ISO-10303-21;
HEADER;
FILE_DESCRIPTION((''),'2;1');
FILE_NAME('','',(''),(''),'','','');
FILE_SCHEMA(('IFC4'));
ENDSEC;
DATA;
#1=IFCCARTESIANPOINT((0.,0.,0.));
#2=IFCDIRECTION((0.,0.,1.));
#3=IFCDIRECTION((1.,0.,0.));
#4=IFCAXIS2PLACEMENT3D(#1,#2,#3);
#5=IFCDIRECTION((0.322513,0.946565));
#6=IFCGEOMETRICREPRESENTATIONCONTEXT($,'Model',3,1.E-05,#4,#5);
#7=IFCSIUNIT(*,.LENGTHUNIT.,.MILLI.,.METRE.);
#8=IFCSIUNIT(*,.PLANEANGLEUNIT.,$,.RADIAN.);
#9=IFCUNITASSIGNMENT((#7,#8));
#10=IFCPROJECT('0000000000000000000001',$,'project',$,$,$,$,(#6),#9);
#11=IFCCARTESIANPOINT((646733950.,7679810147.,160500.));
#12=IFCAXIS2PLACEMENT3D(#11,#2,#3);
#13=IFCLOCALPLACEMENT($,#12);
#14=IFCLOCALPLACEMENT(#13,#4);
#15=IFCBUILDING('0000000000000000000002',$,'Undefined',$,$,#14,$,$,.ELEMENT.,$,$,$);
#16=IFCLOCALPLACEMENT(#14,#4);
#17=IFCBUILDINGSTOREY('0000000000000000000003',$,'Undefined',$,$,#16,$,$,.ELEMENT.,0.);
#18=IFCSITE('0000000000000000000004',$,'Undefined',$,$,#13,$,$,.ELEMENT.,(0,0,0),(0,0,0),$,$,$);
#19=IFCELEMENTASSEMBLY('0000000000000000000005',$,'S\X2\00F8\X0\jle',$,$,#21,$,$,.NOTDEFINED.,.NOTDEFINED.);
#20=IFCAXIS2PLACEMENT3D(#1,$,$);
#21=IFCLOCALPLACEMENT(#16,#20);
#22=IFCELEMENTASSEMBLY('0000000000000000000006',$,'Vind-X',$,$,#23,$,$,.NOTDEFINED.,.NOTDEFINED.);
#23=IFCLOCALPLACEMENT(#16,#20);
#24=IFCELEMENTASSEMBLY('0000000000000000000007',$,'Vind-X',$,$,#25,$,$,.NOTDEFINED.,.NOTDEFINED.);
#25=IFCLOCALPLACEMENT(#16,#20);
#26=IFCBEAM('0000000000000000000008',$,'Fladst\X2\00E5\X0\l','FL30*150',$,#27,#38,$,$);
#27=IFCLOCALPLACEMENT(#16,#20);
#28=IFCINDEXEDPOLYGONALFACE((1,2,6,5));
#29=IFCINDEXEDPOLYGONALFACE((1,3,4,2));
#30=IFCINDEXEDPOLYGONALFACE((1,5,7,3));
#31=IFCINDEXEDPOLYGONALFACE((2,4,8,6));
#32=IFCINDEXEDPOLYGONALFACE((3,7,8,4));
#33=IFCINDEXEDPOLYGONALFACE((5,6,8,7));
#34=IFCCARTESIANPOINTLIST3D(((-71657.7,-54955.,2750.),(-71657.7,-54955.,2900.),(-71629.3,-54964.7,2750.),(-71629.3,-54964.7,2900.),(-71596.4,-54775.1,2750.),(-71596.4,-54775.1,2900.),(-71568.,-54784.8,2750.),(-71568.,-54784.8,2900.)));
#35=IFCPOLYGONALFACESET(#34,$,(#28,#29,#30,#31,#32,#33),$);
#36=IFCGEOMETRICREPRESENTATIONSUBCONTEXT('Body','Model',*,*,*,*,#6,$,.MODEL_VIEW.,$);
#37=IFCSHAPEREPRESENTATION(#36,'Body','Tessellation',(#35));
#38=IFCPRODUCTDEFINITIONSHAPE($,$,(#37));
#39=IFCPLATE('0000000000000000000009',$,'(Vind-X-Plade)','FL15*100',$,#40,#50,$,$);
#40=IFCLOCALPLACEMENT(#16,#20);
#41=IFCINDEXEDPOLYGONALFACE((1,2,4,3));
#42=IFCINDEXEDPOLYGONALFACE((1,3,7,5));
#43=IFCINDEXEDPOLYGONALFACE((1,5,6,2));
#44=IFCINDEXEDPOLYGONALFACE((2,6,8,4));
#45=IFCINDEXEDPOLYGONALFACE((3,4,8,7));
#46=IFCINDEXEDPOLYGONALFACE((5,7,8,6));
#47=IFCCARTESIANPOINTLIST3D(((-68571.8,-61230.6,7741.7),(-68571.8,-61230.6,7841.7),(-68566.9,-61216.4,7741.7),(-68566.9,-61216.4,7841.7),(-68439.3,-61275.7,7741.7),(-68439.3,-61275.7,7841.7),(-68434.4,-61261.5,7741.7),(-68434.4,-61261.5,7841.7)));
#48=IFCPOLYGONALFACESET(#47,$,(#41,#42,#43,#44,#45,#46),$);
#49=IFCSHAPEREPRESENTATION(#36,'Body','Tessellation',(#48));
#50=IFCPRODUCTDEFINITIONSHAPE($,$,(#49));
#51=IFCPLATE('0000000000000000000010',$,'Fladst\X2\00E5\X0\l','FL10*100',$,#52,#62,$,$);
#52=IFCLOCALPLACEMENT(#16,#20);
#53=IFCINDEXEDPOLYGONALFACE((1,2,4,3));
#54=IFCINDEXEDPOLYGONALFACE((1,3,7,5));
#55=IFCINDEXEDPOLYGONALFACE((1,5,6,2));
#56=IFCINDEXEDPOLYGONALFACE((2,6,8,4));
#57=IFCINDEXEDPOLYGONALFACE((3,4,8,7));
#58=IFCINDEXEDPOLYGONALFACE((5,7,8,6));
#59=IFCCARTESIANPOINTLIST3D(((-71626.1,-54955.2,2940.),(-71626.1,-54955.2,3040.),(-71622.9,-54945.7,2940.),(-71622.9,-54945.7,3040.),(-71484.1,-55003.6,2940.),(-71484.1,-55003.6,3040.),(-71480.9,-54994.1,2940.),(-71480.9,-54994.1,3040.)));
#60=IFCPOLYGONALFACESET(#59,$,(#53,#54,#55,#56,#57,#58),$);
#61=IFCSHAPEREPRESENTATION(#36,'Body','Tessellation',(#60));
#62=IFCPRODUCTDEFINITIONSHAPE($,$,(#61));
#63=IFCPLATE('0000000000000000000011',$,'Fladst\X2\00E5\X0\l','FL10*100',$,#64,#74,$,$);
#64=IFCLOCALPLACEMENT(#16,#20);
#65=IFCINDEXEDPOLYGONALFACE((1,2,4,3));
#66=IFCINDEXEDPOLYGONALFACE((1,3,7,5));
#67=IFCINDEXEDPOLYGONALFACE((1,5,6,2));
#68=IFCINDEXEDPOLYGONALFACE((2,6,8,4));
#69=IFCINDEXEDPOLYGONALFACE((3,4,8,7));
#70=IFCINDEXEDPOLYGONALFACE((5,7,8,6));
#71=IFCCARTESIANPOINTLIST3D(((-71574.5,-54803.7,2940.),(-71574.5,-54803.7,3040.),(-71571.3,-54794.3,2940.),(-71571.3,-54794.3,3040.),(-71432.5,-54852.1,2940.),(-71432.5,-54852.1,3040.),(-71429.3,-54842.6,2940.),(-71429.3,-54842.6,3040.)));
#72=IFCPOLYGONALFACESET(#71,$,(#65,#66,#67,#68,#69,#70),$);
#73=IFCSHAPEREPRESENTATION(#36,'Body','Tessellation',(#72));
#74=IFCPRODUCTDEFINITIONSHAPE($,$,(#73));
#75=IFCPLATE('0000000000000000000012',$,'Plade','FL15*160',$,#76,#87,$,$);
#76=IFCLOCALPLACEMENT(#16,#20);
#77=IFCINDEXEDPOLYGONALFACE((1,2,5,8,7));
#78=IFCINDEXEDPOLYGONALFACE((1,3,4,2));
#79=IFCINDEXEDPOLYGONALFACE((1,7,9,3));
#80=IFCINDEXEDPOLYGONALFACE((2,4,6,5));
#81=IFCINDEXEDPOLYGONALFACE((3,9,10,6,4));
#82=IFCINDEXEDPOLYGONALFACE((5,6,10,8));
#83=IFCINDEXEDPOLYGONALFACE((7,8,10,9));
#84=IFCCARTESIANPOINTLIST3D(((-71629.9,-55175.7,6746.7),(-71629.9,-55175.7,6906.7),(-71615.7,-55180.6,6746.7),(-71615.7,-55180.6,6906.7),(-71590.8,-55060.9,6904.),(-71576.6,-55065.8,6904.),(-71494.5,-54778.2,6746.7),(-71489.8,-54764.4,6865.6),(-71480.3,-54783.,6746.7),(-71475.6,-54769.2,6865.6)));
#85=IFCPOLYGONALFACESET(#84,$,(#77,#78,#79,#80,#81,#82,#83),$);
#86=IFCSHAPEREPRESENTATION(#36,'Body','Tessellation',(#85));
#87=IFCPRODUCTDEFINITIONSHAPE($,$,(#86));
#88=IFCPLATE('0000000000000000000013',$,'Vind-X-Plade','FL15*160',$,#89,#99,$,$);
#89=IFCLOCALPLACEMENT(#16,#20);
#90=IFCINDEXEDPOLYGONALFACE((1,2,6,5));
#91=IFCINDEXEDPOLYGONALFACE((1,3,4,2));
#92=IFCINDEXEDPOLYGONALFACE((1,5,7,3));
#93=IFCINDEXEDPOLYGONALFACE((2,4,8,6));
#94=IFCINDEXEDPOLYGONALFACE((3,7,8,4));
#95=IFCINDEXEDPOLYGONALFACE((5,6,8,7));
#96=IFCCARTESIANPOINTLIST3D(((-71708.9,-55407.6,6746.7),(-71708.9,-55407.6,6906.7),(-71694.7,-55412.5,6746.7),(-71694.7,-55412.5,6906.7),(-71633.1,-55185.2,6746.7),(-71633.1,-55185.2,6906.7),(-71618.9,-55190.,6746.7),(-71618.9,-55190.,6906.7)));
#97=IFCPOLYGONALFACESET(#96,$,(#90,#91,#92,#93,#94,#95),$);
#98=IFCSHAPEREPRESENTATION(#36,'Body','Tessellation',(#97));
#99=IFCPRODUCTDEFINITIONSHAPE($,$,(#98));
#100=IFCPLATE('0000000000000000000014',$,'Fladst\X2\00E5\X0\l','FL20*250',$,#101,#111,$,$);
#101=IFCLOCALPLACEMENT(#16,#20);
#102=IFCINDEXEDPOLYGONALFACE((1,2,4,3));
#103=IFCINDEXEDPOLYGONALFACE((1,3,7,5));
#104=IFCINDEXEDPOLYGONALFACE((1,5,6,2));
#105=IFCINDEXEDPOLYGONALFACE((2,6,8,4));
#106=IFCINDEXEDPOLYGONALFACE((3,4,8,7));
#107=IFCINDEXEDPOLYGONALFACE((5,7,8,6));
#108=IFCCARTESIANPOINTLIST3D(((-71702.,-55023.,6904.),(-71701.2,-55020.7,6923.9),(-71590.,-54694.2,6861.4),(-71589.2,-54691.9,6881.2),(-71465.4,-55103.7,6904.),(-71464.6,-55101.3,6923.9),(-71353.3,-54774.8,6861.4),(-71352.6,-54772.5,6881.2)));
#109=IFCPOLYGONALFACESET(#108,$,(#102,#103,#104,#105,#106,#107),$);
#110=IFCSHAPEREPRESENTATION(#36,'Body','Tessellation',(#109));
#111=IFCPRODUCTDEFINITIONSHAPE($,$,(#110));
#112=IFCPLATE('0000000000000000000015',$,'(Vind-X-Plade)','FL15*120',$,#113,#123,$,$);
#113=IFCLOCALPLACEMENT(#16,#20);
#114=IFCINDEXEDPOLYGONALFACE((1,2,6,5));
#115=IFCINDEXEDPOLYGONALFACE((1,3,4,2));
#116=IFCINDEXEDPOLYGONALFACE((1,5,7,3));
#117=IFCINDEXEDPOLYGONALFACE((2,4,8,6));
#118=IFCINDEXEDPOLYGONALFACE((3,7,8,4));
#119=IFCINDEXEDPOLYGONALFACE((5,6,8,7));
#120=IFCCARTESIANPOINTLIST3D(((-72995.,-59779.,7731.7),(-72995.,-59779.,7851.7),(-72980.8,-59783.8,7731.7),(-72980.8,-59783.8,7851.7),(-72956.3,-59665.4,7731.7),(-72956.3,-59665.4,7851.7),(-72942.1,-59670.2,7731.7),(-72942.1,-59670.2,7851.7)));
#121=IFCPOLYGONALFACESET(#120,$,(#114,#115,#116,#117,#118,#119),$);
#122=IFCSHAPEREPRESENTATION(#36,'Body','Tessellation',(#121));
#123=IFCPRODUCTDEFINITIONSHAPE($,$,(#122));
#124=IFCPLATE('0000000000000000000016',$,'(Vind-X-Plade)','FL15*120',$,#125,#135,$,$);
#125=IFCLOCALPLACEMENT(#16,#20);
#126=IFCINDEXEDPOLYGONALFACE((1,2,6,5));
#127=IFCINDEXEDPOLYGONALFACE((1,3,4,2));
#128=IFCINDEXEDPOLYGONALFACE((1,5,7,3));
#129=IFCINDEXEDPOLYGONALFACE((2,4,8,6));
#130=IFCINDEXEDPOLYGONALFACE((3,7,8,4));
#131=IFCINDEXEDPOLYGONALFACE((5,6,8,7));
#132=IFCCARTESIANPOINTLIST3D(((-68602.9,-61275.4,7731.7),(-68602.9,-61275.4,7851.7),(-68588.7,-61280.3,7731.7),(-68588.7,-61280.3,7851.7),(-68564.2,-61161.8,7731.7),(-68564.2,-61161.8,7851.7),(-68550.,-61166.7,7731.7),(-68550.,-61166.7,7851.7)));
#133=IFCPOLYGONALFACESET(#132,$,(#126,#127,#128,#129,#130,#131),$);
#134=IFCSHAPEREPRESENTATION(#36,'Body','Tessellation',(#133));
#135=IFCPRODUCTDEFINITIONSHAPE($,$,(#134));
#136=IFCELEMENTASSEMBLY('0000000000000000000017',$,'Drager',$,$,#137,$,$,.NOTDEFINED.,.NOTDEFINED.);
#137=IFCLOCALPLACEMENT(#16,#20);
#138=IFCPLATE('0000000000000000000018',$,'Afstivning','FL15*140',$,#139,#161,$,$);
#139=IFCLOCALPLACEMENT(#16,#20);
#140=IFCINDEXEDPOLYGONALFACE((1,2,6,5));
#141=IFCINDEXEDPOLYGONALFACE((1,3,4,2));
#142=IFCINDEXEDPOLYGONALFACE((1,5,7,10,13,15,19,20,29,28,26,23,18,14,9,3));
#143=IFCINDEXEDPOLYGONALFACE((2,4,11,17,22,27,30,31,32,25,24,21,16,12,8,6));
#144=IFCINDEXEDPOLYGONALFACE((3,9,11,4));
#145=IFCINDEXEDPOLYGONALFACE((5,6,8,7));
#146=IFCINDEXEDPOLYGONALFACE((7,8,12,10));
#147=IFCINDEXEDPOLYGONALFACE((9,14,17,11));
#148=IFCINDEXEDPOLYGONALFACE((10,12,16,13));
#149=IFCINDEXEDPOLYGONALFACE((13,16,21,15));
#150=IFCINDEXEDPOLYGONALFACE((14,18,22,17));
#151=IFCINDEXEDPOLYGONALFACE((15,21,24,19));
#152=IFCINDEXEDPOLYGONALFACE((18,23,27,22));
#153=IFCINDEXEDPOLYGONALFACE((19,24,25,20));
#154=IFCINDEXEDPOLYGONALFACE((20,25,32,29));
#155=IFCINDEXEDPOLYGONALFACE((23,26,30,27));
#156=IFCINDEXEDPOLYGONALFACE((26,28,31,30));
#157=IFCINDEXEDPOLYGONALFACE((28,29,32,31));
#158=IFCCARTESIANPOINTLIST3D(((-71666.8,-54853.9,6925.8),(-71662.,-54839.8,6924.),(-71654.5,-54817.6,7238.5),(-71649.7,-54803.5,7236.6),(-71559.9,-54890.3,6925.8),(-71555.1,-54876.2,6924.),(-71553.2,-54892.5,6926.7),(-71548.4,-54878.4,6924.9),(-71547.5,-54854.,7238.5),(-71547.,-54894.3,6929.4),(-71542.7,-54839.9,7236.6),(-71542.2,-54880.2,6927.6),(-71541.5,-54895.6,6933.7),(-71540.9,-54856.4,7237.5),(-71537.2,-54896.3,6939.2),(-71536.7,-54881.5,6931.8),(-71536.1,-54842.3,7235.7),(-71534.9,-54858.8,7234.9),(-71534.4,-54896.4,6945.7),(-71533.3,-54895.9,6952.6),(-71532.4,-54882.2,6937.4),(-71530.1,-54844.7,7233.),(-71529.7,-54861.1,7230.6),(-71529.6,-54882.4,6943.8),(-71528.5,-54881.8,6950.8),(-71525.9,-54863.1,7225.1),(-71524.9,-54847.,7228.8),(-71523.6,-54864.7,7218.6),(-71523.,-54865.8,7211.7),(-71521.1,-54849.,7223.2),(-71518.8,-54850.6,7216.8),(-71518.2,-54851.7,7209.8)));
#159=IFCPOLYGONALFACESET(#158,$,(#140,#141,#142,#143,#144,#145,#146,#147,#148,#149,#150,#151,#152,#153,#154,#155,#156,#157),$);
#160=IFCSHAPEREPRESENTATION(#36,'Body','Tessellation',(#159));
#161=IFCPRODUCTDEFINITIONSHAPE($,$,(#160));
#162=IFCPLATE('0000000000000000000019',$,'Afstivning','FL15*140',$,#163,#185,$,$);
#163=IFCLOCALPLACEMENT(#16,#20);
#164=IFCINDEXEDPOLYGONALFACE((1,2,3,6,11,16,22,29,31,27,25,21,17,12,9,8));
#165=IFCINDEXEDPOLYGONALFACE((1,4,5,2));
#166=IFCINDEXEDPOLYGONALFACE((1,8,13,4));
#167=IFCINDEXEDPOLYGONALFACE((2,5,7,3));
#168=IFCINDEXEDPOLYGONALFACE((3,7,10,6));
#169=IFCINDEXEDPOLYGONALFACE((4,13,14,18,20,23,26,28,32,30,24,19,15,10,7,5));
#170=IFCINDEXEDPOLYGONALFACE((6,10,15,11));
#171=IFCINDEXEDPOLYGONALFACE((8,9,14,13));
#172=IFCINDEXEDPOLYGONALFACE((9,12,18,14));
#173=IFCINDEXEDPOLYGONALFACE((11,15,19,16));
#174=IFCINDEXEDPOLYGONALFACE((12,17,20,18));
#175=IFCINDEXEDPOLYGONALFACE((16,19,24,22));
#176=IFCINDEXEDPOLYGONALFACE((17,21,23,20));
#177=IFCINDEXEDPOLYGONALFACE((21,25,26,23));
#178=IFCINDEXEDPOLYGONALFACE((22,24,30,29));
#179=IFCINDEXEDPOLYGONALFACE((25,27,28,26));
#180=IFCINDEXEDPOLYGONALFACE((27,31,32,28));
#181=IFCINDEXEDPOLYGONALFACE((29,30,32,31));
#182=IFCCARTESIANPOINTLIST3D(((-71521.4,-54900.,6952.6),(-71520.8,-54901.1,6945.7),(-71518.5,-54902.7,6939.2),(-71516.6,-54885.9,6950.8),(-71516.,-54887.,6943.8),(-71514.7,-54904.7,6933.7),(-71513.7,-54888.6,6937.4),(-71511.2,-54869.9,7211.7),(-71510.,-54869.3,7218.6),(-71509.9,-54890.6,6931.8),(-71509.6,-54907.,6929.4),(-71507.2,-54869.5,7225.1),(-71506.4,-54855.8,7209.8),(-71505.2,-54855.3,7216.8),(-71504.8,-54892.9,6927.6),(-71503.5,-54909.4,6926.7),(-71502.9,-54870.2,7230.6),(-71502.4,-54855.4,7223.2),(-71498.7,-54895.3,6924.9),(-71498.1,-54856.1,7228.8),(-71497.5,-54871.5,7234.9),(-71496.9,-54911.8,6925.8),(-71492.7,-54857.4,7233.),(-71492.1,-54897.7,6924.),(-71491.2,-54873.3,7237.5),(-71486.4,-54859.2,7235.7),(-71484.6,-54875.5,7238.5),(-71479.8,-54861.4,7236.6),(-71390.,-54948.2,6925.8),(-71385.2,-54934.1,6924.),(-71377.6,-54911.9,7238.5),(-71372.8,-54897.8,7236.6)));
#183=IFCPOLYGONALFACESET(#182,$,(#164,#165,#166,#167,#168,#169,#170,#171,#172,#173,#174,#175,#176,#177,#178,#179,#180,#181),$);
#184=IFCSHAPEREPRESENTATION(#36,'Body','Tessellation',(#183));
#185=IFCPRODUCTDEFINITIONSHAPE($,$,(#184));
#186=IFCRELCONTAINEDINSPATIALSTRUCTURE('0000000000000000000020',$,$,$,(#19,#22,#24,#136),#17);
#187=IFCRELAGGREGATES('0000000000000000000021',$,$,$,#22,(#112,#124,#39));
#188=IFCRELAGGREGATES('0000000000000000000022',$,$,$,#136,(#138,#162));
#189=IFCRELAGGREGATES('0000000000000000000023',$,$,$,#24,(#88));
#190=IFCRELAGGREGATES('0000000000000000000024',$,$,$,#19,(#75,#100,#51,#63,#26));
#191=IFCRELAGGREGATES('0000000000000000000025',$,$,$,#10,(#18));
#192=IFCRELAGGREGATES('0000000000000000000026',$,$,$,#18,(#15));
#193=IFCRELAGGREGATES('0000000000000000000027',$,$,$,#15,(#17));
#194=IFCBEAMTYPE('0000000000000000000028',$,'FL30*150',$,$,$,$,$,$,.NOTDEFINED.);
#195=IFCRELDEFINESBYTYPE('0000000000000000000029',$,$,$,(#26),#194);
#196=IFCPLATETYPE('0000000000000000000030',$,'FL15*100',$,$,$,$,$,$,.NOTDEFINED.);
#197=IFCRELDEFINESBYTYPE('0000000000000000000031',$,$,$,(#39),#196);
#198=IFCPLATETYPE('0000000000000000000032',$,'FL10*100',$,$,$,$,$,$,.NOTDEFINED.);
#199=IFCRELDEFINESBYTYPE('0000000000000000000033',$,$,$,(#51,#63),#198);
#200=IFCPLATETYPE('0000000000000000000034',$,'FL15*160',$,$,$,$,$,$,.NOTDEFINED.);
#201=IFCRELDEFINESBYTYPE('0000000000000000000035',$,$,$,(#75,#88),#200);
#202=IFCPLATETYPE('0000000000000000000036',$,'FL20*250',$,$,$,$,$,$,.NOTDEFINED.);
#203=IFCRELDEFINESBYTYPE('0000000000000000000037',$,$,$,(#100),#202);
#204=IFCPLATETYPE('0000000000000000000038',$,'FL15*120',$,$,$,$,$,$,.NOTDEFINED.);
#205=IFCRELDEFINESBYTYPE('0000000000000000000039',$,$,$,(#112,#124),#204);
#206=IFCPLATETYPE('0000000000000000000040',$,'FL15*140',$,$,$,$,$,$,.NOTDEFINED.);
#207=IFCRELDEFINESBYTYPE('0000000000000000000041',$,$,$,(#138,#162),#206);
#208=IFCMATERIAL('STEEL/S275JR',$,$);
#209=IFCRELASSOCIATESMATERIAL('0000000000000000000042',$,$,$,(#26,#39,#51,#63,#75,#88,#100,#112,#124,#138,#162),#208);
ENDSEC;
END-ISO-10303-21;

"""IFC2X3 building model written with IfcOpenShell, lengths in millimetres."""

from ifc_helpers import new_model, si_unit, direction, frame, frame_2d, origin_with_axes, origin_2d_with_axis, place, context, subcontext, project, spatial, polyline, circle_curve, parameter, trimmed, segment, composite_curve, rectangle, outline, extrude, material, type_object, element, aggregate, save


model = new_model("IFC2X3")

# Units and contexts
model_context = context("Model", 3, precision=1e-05, world=origin_with_axes(), true_north=direction((0.322513, 0.946565)))
body_context = subcontext(model_context, "Body", "Model", "MODEL_VIEW")
ifc_project = project(units=[si_unit("LENGTHUNIT", "METRE", prefix="MILLI"), si_unit("PLANEANGLEUNIT", "RADIAN")], contexts=[model_context])

# Site, building, storey
site_placement = place(None, frame((646733950.0, 7679810147.0, 160500.0), z_axis=(0.0, 0.0, 1.0), x_axis=(1.0, 0.0, 0.0)))
site = spatial("IfcSite", under=ifc_project, at=site_placement, Name="Undefined", CompositionType="ELEMENT", RefLatitude=(0, 0, 0), RefLongitude=(0, 0, 0))
building_placement = place(site_placement, origin_with_axes())
building = spatial("IfcBuilding", under=site, at=building_placement, Name="Undefined", CompositionType="ELEMENT")
storey_placement = place(building_placement, origin_with_axes())
storey = spatial("IfcBuildingStorey", under=building, at=storey_placement, Name="Undefined", CompositionType="ELEMENT", Elevation=0.0)

# Element assembly
assembly_1_placement = place(storey_placement, origin_with_axes())
assembly_1 = element("IfcElementAssembly", 1, at=assembly_1_placement, inside=storey, Name="Søjle", AssemblyPlace="NOTDEFINED", PredefinedType="NOTDEFINED")

# Element assemblies
assembly_2_placement = place(storey_placement, origin_with_axes())
assembly_2 = element("IfcElementAssembly", 2, at=assembly_2_placement, inside=storey, Name="Vind-X", AssemblyPlace="NOTDEFINED", PredefinedType="NOTDEFINED")
assembly_3_placement = place(storey_placement, origin_with_axes())
assembly_3 = element("IfcElementAssembly", 3, at=assembly_3_placement, inside=storey, Name="Vind-X", AssemblyPlace="NOTDEFINED", PredefinedType="NOTDEFINED")

# Beam
ifc_material_1 = material(Name="STEEL/S275JR")
beam_type_1 = type_object("IfcBeamType", Name="FL30*150", PredefinedType="NOTDEFINED")
beam_1_placement = place(assembly_1_placement, frame((-71612.9, -54869.9, 2900.0), z_axis=(-0.322513, -0.946565, 0.0), x_axis=(0.0, 0.0, -1.0)))
beam_1 = element("IfcBeam", 4, at=beam_1_placement, type_object=beam_type_1, material=ifc_material_1, Name="Fladstål", Description="FL30*150", context=body_context, shape_type="SweptSolid", body=[
    extrude(rectangle(XDim=30.0, YDim=190.0, at=origin_2d_with_axis()), frame((150.0, 0.0, 0.0), z_axis=(-1.0, 0.0, 0.0), x_axis=(0.0, -1.0, 0.0)), (0.0, 0.0, 1.0), 150.0),
])

# Plates
plate_type_1 = type_object("IfcPlateType", Name="FL15*100", PredefinedType="NOTDEFINED")
plate_1_placement = place(assembly_2_placement, frame((-68436.8, -61268.6, 7741.7), z_axis=(-0.322513, -0.946565, 0.0), x_axis=(0.0, 0.0, 1.0)))
plate_1 = element("IfcPlate", 5, at=plate_1_placement, type_object=plate_type_1, material=ifc_material_1, Name="(Vind-X-Plade)", Description="FL15*100", context=body_context, shape_type="SweptSolid", body=[
    extrude(outline(polyline([(0.0, 0.0), (100.0, 0.0), (100.0, 140.0), (0.0, 140.0), (0.0, 0.0)])), frame((0.0, 0.0, -7.5), z_axis=(0.0, 0.0, 1.0), x_axis=(1.0, 0.0, 0.0)), (0.0, 0.0, 1.0), 15.0),
])
plate_type_2 = type_object("IfcPlateType", Name="FL10*100", PredefinedType="NOTDEFINED")
plate_2_placement = place(assembly_1_placement, frame((-71482.5, -54998.8, 3040.0), z_axis=(-0.322513, -0.946565, 0.0), x_axis=(-0.946565, 0.322513, 0.0)))
plate_2 = element("IfcPlate", 6, at=plate_2_placement, type_object=plate_type_2, material=ifc_material_1, Name="Fladstål", Description="FL10*100", context=body_context, shape_type="SweptSolid", body=[
    extrude(outline(polyline([(0.0, 0.0), (150.0, 0.0), (150.0, 100.0), (0.0, 100.0), (0.0, 0.0)])), frame((0.0, 0.0, -5.0), z_axis=(0.0, 0.0, 1.0), x_axis=(1.0, 0.0, 0.0)), (0.0, 0.0, 1.0), 10.0),
])
plate_3_placement = place(assembly_1_placement, frame((-71430.9, -54847.4, 3040.0), z_axis=(-0.322513, -0.946565, 0.0), x_axis=(-0.946565, 0.322513, 0.0)))
plate_3 = element("IfcPlate", 7, at=plate_3_placement, type_object=plate_type_2, material=ifc_material_1, Name="Fladstål", Description="FL10*100", context=body_context, shape_type="SweptSolid", body=[
    extrude(outline(polyline([(0.0, 0.0), (150.0, 0.0), (150.0, 100.0), (0.0, 100.0), (0.0, 0.0)])), frame((0.0, 0.0, -5.0), z_axis=(0.0, 0.0, 1.0), x_axis=(1.0, 0.0, 0.0)), (0.0, 0.0, 1.0), 10.0),
])
plate_type_3 = type_object("IfcPlateType", Name="FL15*160", PredefinedType="NOTDEFINED")
plate_4_placement = place(assembly_1_placement, frame((-71482.7, -54766.8, 6865.6), z_axis=(-0.946565, 0.322513, 0.0), x_axis=(-0.039304, -0.115357, -0.992546)))
plate_4 = element("IfcPlate", 8, at=plate_4_placement, type_object=plate_type_3, material=ifc_material_1, Name="Plade", Description="FL15*160", context=body_context, shape_type="SweptSolid", body=[
    extrude(outline(polyline([(0.0, 0.0), (119.8, 0.0), (171.0, 416.9), (12.2, 436.4), (0.0, 315.6), (0.0, 0.0)])), frame((0.0, 0.0, -7.5), z_axis=(0.0, 0.0, 1.0), x_axis=(1.0, 0.0, 0.0)), (0.0, 0.0, 1.0), 15.0),
])
plate_5_placement = place(assembly_3_placement, frame((-71626.0, -55187.6, 6826.7), z_axis=(0.946565, -0.322513, 0.0), x_axis=(-0.322513, -0.946565, 0.0)))
plate_5 = element("IfcPlate", 9, at=plate_5_placement, type_object=plate_type_3, material=ifc_material_1, Name="Vind-X-Plade", Description="FL15*160", context=body_context, shape_type="SweptSolid", body=[
    extrude(outline(polyline([(0.0, -80.0), (0.0, 80.0), (235.0, 80.0), (235.0, -80.0), (0.0, -80.0)])), frame((0.0, 0.0, -7.5), z_axis=(0.0, 0.0, 1.0), x_axis=(1.0, 0.0, 0.0)), (0.0, 0.0, 1.0), 15.0),
])
plate_type_4 = type_object("IfcPlateType", Name="FL20*250", PredefinedType="NOTDEFINED")
plate_6_placement = place(assembly_1_placement, frame((-71471.3, -54733.4, 6871.3), z_axis=(-0.039304, -0.115357, -0.992546), x_axis=(-0.320109, -0.93951, 0.121869)))
plate_6 = element("IfcPlate", 10, at=plate_6_placement, type_object=plate_type_4, material=ifc_material_1, Name="Fladstål", Description="FL20*250", context=body_context, shape_type="SweptSolid", body=[
    extrude(outline(polyline([(0.0, -125.0), (0.0, 125.0), (350.0, 125.0), (350.0, -125.0), (0.0, -125.0)])), frame((0.0, 0.0, -10.0), z_axis=(0.0, 0.0, 1.0), x_axis=(1.0, 0.0, 0.0)), (0.0, 0.0, 1.0), 20.0),
])
plate_type_5 = type_object("IfcPlateType", Name="FL15*120", PredefinedType="NOTDEFINED")
plate_7_placement = place(assembly_2_placement, frame((-72987.9, -59781.4, 7851.7), z_axis=(-0.946565, 0.322513, 0.0), x_axis=(0.322513, 0.946565, 0.0)))
plate_7 = element("IfcPlate", 11, at=plate_7_placement, type_object=plate_type_5, material=ifc_material_1, Name="(Vind-X-Plade)", Description="FL15*120", context=body_context, shape_type="SweptSolid", body=[
    extrude(outline(polyline([(0.0, 0.0), (120.0, 0.0), (120.0, 120.0), (0.0, 120.0), (0.0, 0.0)])), frame((0.0, 0.0, -7.5), z_axis=(0.0, 0.0, 1.0), x_axis=(1.0, 0.0, 0.0)), (0.0, 0.0, 1.0), 15.0),
])
plate_8_placement = place(assembly_2_placement, frame((-68557.1, -61164.3, 7851.7), z_axis=(0.946565, -0.322513, 0.0), x_axis=(-0.322513, -0.946565, 0.0)))
plate_8 = element("IfcPlate", 12, at=plate_8_placement, type_object=plate_type_5, material=ifc_material_1, Name="(Vind-X-Plade)", Description="FL15*120", context=body_context, shape_type="SweptSolid", body=[
    extrude(outline(polyline([(0.0, 0.0), (120.0, 0.0), (120.0, 120.0), (0.0, 120.0), (0.0, 0.0)])), frame((0.0, 0.0, -7.5), z_axis=(0.0, 0.0, 1.0), x_axis=(1.0, 0.0, 0.0)), (0.0, 0.0, 1.0), 15.0),
])
aggregate(assembly_2, [plate_7, plate_8, plate_1])

# Element assembly, plates
assembly_4_placement = place(storey_placement, origin_with_axes())
assembly_4 = element("IfcElementAssembly", 13, at=assembly_4_placement, inside=storey, Name="Drager", AssemblyPlace="NOTDEFINED", PredefinedType="NOTDEFINED")
plate_type_6 = type_object("IfcPlateType", Name="FL15*140", PredefinedType="NOTDEFINED")
plate_9_placement = place(assembly_4_placement, frame((-71531.9, -54892.0, 6924.9), z_axis=(0.320109, 0.93951, -0.121869), x_axis=(-0.946565, 0.322513, 0.0)))
plate_9 = element("IfcPlate", 14, at=plate_9_placement, type_object=plate_type_6, material=ifc_material_1, Name="Afstivning", Description="FL15*140", context=body_context, shape_type="SweptSolid", body=[
    extrude(outline(composite_curve([segment(trimmed(circle_curve(frame_2d((27.0, 27.0), x_axis=(-1.0, 0.0)), 27.0), [parameter(0.0)], [parameter(1.570796)], True, "PARAMETER"), True, "CONTINUOUS"), segment(polyline([(27.0, 0.0), (140.0, 0.0), (140.0, 315.0), (27.0, 315.0)]), True, "CONTINUOUS"), segment(trimmed(circle_curve(frame_2d((27.0, 288.0), x_axis=(0.0, 1.0)), 27.0), [parameter(0.0)], [parameter(1.570796)], True, "PARAMETER"), True, "CONTINUOUS"), segment(polyline([(0.0, 288.0), (0.0, 27.0)]), True, "CONTINUOUS")], self_intersect=True)), frame((0.0, 0.0, -7.5), z_axis=(0.0, 0.0, 1.0), x_axis=(1.0, 0.0, 0.0)), (0.0, 0.0, 1.0), 15.0),
])
plate_10_placement = place(assembly_4_placement, frame((-71387.6, -54941.2, 6924.9), z_axis=(0.320109, 0.93951, -0.121869), x_axis=(-0.946565, 0.322513, 0.0)))
plate_10 = element("IfcPlate", 15, at=plate_10_placement, type_object=plate_type_6, material=ifc_material_1, Name="Afstivning", Description="FL15*140", context=body_context, shape_type="SweptSolid", body=[
    extrude(outline(composite_curve([segment(polyline([(0.0, 0.0), (113.0, 0.0)]), True, "CONTINUOUS"), segment(trimmed(circle_curve(frame_2d((113.0, 27.0), x_axis=(0.0, -1.0)), 27.0), [parameter(0.0)], [parameter(1.570796)], True, "PARAMETER"), True, "CONTINUOUS"), segment(polyline([(140.0, 27.0), (140.0, 288.0)]), True, "CONTINUOUS"), segment(trimmed(circle_curve(frame_2d((113.0, 288.0), x_axis=(1.0, 0.0)), 27.0), [parameter(0.0)], [parameter(1.570796)], True, "PARAMETER"), True, "CONTINUOUS"), segment(polyline([(113.0, 315.0), (0.0, 315.0), (0.0, 0.0)]), True, "CONTINUOUS")], self_intersect=True)), frame((0.0, 0.0, -7.5), z_axis=(0.0, 0.0, 1.0), x_axis=(1.0, 0.0, 0.0)), (0.0, 0.0, 1.0), 15.0),
])
aggregate(assembly_4, [plate_9, plate_10])

aggregate(assembly_3, [plate_5])

aggregate(assembly_1, [plate_4, plate_6, plate_2, plate_3, beam_1])

save(model, "model.ifc")
